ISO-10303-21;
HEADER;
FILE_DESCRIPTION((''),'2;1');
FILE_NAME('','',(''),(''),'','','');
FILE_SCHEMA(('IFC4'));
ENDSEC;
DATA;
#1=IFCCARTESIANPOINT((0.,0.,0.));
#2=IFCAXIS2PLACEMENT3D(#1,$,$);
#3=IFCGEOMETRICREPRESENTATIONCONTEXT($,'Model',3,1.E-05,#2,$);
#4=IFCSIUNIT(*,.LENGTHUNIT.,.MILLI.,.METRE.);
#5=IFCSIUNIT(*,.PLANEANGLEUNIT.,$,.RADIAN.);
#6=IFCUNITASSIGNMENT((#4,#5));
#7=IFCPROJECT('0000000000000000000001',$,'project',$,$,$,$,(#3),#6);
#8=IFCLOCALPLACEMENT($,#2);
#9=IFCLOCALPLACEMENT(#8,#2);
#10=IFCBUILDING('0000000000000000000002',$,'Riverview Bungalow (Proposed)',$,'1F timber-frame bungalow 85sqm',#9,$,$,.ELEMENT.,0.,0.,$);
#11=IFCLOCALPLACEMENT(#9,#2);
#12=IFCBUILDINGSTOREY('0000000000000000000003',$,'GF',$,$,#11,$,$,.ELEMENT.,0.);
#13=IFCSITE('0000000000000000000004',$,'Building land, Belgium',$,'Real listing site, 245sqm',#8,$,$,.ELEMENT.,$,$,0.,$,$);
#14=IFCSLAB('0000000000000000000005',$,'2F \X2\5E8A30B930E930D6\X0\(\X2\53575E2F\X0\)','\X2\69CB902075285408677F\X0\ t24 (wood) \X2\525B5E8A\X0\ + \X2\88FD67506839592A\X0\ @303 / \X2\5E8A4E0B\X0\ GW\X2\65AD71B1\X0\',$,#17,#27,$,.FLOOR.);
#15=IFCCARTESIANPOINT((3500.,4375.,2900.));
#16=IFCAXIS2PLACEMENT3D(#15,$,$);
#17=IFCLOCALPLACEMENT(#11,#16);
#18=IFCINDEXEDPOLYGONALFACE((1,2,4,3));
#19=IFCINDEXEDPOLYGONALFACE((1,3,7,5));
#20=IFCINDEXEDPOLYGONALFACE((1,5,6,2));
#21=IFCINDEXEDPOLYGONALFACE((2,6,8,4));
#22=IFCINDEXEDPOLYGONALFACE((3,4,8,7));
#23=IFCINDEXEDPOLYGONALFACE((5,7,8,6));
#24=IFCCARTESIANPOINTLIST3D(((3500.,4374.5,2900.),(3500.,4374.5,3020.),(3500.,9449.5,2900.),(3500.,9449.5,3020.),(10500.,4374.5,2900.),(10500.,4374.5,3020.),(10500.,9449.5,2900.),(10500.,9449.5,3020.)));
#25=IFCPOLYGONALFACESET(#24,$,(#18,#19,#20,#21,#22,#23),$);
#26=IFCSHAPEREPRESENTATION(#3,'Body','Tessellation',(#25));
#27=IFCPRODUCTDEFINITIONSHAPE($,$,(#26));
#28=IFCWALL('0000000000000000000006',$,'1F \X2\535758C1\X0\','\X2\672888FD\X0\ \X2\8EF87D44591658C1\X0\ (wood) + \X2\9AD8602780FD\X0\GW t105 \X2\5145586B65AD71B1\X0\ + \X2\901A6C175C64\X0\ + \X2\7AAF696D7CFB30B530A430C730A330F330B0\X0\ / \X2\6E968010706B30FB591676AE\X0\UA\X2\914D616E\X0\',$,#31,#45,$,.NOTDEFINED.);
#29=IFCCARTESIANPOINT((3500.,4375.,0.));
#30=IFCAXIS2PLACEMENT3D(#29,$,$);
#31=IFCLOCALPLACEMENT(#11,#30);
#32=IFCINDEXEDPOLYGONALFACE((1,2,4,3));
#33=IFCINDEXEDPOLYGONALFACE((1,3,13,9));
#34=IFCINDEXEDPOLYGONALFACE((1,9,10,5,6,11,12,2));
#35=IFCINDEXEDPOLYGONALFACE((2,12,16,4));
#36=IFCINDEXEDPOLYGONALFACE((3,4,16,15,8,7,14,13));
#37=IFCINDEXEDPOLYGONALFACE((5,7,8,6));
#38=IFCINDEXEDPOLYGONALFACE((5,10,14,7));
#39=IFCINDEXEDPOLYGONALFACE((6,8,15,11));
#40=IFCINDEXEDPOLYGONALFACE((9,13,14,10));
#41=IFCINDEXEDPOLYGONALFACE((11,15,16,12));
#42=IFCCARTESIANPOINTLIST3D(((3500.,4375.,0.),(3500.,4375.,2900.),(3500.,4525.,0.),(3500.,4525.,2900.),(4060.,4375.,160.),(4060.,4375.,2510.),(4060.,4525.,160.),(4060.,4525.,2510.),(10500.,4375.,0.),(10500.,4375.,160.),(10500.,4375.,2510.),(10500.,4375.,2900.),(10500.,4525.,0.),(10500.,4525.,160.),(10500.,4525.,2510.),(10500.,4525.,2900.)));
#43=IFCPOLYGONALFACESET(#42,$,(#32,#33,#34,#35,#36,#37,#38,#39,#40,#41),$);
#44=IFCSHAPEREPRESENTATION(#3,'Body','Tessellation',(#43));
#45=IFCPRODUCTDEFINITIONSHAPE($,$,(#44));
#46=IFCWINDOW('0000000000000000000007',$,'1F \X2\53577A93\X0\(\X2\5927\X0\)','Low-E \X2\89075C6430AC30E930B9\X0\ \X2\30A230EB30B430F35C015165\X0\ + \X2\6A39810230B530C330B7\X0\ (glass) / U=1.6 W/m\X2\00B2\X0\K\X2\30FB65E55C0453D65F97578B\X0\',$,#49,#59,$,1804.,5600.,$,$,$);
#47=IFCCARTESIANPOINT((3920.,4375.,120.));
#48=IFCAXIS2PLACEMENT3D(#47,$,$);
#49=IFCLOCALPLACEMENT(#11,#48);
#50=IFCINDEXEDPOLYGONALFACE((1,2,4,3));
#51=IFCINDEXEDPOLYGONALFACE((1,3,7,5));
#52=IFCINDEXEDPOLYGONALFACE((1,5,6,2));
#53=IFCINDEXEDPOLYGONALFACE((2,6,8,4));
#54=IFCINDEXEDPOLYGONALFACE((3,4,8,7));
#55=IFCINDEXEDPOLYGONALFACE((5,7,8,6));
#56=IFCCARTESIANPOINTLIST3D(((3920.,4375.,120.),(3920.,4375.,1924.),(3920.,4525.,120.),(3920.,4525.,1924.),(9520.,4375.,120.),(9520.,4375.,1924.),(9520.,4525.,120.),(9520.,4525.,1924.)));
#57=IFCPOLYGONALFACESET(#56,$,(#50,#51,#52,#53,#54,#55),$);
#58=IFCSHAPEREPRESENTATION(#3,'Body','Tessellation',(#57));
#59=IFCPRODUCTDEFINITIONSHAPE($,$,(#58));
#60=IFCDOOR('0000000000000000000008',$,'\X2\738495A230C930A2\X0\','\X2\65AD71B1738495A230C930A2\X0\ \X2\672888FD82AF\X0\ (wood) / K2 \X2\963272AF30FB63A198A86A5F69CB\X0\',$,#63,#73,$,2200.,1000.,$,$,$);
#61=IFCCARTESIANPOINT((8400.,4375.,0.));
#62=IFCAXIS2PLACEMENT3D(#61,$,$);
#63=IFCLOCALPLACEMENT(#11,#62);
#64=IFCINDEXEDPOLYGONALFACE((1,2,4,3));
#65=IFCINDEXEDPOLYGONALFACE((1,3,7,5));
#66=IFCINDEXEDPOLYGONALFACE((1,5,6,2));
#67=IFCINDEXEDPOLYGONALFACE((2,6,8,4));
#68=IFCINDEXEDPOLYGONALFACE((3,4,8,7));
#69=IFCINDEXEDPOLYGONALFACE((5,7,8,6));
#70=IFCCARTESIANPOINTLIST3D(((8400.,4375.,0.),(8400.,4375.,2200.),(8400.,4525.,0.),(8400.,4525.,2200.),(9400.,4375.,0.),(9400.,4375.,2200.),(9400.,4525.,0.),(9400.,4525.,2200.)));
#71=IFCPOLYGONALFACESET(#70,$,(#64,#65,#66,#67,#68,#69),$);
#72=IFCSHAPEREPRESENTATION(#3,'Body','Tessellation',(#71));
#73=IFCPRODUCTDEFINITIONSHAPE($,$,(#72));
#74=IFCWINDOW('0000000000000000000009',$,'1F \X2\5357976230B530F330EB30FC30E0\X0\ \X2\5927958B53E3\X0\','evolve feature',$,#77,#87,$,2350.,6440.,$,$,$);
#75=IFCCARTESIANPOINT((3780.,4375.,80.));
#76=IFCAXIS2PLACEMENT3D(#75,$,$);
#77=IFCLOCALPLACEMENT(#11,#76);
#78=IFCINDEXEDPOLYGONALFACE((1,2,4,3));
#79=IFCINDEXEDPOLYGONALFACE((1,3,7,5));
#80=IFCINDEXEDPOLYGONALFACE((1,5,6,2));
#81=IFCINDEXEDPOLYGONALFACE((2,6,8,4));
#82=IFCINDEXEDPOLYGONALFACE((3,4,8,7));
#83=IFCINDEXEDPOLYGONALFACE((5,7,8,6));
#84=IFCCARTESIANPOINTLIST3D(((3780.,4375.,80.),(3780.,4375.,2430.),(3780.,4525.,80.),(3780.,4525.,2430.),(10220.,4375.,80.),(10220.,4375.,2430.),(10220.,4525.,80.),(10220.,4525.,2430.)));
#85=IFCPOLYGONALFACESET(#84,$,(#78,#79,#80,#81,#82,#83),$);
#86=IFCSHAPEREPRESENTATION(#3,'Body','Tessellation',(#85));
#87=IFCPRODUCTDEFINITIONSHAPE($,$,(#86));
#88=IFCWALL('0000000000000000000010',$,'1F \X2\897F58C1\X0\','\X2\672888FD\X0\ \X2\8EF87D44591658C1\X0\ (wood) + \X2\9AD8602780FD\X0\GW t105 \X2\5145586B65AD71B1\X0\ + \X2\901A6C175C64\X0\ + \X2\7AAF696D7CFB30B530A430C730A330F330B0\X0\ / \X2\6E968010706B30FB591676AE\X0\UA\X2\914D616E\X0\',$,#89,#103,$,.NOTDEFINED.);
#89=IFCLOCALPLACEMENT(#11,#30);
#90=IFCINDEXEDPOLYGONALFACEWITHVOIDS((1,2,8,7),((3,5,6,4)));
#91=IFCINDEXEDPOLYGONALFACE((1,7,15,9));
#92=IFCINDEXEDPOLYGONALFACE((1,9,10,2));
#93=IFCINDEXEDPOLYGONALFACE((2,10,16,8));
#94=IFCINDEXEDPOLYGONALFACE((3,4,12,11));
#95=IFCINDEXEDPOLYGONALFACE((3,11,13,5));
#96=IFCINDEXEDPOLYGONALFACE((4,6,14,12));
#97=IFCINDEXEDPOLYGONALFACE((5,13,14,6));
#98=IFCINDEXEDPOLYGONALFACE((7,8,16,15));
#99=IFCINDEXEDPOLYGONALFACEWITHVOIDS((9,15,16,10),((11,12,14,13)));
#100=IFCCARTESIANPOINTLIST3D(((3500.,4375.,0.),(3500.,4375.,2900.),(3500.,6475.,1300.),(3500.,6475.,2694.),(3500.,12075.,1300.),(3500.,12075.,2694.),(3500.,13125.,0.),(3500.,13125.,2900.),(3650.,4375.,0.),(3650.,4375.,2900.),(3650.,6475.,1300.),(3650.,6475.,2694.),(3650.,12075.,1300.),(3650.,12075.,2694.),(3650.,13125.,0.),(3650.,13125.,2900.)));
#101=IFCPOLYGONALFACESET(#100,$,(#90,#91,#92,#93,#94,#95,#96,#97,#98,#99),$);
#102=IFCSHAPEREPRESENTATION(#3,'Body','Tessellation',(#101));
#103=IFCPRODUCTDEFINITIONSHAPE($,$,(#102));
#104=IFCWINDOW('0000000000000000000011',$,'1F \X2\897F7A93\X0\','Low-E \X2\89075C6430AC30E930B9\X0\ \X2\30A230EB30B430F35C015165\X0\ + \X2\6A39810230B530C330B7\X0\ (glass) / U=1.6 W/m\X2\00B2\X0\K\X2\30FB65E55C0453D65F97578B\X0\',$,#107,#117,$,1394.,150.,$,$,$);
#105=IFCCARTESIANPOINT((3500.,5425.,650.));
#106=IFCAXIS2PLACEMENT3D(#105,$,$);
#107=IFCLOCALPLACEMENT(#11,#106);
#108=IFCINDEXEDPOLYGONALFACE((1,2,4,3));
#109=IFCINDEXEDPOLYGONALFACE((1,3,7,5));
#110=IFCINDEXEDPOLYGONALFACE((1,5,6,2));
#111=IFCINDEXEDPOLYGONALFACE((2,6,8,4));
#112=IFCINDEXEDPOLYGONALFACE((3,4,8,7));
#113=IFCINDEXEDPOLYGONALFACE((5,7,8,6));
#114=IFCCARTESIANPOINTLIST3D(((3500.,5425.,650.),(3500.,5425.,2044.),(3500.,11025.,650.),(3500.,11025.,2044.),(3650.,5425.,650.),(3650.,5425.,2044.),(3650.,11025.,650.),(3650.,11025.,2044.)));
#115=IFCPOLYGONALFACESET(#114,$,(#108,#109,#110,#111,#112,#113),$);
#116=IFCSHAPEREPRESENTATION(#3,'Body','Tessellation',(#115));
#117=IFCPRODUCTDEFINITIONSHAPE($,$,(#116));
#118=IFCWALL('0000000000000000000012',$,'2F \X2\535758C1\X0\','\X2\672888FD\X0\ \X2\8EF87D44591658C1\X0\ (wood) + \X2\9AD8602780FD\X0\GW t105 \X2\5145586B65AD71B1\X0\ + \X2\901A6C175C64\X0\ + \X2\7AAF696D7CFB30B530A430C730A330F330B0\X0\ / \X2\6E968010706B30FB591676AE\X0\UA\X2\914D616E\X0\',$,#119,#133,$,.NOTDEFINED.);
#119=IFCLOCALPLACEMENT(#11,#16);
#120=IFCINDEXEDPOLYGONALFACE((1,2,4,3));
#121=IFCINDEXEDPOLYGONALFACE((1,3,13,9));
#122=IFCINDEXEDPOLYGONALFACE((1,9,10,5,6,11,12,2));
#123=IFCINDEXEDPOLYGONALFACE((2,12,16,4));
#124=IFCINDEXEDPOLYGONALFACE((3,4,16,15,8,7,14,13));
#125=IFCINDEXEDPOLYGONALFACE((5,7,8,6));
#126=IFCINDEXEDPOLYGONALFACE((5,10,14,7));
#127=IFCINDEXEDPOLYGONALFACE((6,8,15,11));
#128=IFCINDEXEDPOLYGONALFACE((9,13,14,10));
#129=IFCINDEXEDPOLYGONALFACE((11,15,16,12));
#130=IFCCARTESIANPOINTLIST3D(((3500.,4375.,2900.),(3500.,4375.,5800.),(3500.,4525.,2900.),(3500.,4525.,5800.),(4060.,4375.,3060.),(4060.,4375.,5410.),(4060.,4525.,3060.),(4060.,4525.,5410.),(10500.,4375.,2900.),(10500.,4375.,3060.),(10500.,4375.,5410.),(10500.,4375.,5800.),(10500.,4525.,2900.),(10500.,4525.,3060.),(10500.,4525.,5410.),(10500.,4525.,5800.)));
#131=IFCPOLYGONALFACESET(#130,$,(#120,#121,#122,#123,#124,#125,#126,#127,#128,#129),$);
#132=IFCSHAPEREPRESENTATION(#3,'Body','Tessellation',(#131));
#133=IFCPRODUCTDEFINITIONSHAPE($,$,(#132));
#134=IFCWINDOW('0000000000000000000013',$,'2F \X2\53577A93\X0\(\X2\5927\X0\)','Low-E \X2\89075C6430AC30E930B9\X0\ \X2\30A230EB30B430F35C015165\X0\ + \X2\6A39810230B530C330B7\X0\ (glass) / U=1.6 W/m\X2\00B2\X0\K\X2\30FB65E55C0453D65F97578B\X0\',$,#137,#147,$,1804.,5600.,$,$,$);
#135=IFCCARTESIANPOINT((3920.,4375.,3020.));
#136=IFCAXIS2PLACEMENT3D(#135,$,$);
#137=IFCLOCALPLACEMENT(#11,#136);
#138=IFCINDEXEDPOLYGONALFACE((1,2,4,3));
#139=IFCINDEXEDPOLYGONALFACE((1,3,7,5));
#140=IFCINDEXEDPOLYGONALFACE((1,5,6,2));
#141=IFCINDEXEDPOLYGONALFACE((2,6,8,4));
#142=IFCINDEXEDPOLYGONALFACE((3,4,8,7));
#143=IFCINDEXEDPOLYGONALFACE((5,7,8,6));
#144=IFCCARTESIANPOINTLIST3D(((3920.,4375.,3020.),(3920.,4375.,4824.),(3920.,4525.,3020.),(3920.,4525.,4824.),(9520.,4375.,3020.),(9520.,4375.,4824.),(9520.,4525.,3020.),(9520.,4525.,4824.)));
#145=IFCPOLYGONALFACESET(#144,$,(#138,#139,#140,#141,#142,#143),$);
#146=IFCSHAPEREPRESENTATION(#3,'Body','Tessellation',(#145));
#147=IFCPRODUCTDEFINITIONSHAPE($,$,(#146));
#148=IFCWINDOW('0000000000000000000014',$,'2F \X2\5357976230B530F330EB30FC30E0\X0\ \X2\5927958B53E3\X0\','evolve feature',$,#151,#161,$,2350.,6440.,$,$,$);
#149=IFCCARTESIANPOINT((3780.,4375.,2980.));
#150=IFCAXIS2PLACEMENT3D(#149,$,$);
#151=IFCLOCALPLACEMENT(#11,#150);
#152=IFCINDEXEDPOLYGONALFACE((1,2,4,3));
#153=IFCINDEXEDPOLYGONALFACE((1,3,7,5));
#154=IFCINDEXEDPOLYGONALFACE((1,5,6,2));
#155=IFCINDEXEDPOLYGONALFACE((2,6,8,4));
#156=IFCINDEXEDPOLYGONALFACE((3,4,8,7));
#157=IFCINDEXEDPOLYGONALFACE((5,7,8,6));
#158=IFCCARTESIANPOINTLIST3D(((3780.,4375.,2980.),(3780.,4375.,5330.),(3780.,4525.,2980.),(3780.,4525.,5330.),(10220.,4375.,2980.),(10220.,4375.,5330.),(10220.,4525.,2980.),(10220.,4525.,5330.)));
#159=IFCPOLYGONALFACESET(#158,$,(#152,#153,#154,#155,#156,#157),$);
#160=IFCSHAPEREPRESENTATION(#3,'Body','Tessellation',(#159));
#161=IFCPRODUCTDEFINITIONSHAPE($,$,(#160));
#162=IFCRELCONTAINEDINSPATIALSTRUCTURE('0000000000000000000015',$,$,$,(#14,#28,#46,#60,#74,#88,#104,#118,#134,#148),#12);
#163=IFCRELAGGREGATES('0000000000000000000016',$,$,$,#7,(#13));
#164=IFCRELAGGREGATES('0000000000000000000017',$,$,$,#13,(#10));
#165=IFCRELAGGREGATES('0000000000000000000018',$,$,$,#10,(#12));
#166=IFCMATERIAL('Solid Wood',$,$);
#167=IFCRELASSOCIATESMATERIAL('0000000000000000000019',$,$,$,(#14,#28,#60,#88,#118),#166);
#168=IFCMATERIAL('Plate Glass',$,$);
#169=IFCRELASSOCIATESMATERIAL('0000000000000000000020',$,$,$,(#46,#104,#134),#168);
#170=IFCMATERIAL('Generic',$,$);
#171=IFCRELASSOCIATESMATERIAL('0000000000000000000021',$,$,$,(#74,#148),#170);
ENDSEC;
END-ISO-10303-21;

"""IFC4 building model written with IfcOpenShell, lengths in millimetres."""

from ifc_helpers import new_model, si_unit, frame, frame_2d, origin, place, context, project, spatial, rectangle, extrude, material, element, fill, save


model = new_model("IFC4")

# Units and contexts
model_context = context("Model", 3, precision=1e-05, world=origin())
ifc_project = project(units=[si_unit("LENGTHUNIT", "METRE", prefix="MILLI"), si_unit("PLANEANGLEUNIT", "RADIAN")], contexts=[model_context])

# Site, building, storey
site_placement = place(None, origin())
site = spatial("IfcSite", under=ifc_project, at=site_placement, Name="Building land, Belgium", ObjectType="Real listing site, 245sqm", CompositionType="ELEMENT", RefElevation=0.0)
building_placement = place(site_placement, origin())
building = spatial("IfcBuilding", under=site, at=building_placement, Name="Riverview Bungalow (Proposed)", ObjectType="1F timber-frame bungalow 85sqm", CompositionType="ELEMENT", ElevationOfRefHeight=0.0, ElevationOfTerrain=0.0)
storey_placement = place(building_placement, origin())
storey = spatial("IfcBuildingStorey", under=building, at=storey_placement, Name="GF", CompositionType="ELEMENT", Elevation=0.0)

# Slab
ifc_material_1 = material(Name="Solid Wood")
slab_1_placement = place(storey_placement, frame((3500.0, 4375.0, 2900.0)))
element("IfcSlab", 1, at=slab_1_placement, inside=storey, material=ifc_material_1, Name="2F 床スラブ(南帯)", Description="構造用合板 t24 (wood) 剛床 + 製材根太 @303 / 床下 GW断熱", PredefinedType="FLOOR", context=model_context, shape_type="SweptSolid", body=[
    extrude(rectangle(XDim=7000.0, YDim=5075.0, at=frame_2d((3500.0, 2537.0))), frame((3500.0, 4375.0, 2900.0)), (0.0, 0.0, 1.0), 120.0),
])
ifc_material_2 = material(Name="Generic")

# Wall, openings, windows, door
wall_1_placement = place(storey_placement, frame((3500.0, 4375.0, 0.0)))
wall_1 = element("IfcWall", 2, at=wall_1_placement, inside=storey, material=ifc_material_1, Name="1F 南壁", Description="木製 軸組外壁 (wood) + 高性能GW t105 充填断熱 + 通気層 + 窯業系サイディング / 準耐火・外皮UA配慮", PredefinedType="NOTDEFINED", context=model_context, shape_type="SweptSolid", body=[
    extrude(rectangle(XDim=7000.0, YDim=150.0, at=frame_2d((3500.0, 75.0))), frame((3500.0, 4375.0, 0.0)), (0.0, 0.0, 1.0), 2900.0),
])
opening_1_placement = place(storey_placement, frame((3920.0, 4375.0, 120.0)))
opening_1 = element("IfcOpeningElement", 3, at=opening_1_placement, cuts=wall_1, PredefinedType="NOTDEFINED", context=model_context, shape_type="SweptSolid", body=[
    extrude(rectangle(XDim=5600.0, YDim=150.0, at=frame_2d((2800.0, 75.0))), frame((3920.0, 4375.0, 120.0)), (0.0, 0.0, 1.0), 1804.0),
])
opening_2_placement = place(storey_placement, frame((8400.0, 4375.0, 0.0)))
opening_2 = element("IfcOpeningElement", 4, at=opening_2_placement, cuts=wall_1, PredefinedType="NOTDEFINED", context=model_context, shape_type="SweptSolid", body=[
    extrude(rectangle(XDim=1000.0, YDim=150.0, at=frame_2d((500.0, 75.0))), frame((8400.0, 4375.0, 0.0)), (0.0, 0.0, 1.0), 2200.0),
])
opening_3_placement = place(storey_placement, frame((3780.0, 4375.0, 80.0)))
opening_3 = element("IfcOpeningElement", 5, at=opening_3_placement, cuts=wall_1, PredefinedType="NOTDEFINED", context=model_context, shape_type="SweptSolid", body=[
    extrude(rectangle(XDim=6440.0, YDim=150.0, at=frame_2d((3220.0, 75.0))), frame((3780.0, 4375.0, 80.0)), (0.0, 0.0, 1.0), 2350.0),
])
ifc_material_3 = material(Name="Plate Glass")
window_1_placement = place(storey_placement, frame((3920.0, 4375.0, 120.0)))
window_1 = element("IfcWindow", 6, at=window_1_placement, inside=storey, material=ifc_material_3, Name="1F 南窓(大)", Description="Low-E 複層ガラス アルゴン封入 + 樹脂サッシ (glass) / U=1.6 W/m²K・日射取得型", OverallHeight=1804.0, OverallWidth=5600.0, context=model_context, shape_type="SweptSolid", body=[
    extrude(rectangle(XDim=5600.0, YDim=150.0, at=frame_2d((2800.0, 75.0))), frame((3920.0, 4375.0, 120.0)), (0.0, 0.0, 1.0), 1804.0),
])
fill(opening_1, window_1)
door_placement = place(storey_placement, frame((8400.0, 4375.0, 0.0)))
door = element("IfcDoor", 7, at=door_placement, inside=storey, material=ifc_material_1, Name="玄関ドア", Description="断熱玄関ドア 木製芯 (wood) / K2 防犯・採風機構", OverallHeight=2200.0, OverallWidth=1000.0, context=model_context, shape_type="SweptSolid", body=[
    extrude(rectangle(XDim=1000.0, YDim=150.0, at=frame_2d((500.0, 75.0))), frame((8400.0, 4375.0, 0.0)), (0.0, 0.0, 1.0), 2200.0),
])
fill(opening_2, door)
window_2_placement = place(storey_placement, frame((3780.0, 4375.0, 80.0)))
window_2 = element("IfcWindow", 8, at=window_2_placement, inside=storey, material=ifc_material_2, Name="1F 南面サンルーム 大開口", Description="evolve feature", OverallHeight=2350.0, OverallWidth=6440.0, context=model_context, shape_type="SweptSolid", body=[
    extrude(rectangle(XDim=6440.0, YDim=150.0, at=frame_2d((3220.0, 75.0))), frame((3780.0, 4375.0, 80.0)), (0.0, 0.0, 1.0), 2350.0),
])
fill(opening_3, window_2)

# Wall, opening, window
wall_2_placement = place(storey_placement, frame((3500.0, 4375.0, 0.0)))
wall_2 = element("IfcWall", 9, at=wall_2_placement, inside=storey, material=ifc_material_1, Name="1F 西壁", Description="木製 軸組外壁 (wood) + 高性能GW t105 充填断熱 + 通気層 + 窯業系サイディング / 準耐火・外皮UA配慮", PredefinedType="NOTDEFINED", context=model_context, shape_type="SweptSolid", body=[
    extrude(rectangle(XDim=150.0, YDim=8750.0, at=frame_2d((75.0, 4375.0))), frame((3500.0, 4375.0, 0.0)), (0.0, 0.0, 1.0), 2900.0),
])
opening_4_placement = place(storey_placement, frame((3500.0, 5425.0, 650.0)))
opening_4 = element("IfcOpeningElement", 10, at=opening_4_placement, cuts=wall_2, PredefinedType="NOTDEFINED", context=model_context, shape_type="SweptSolid", body=[
    extrude(rectangle(XDim=150.0, YDim=5600.0, at=frame_2d((75.0, 2800.0))), frame((3500.0, 5425.0, 650.0)), (0.0, 0.0, 1.0), 1394.0),
])
window_3_placement = place(storey_placement, frame((3500.0, 5425.0, 650.0)))
window_3 = element("IfcWindow", 11, at=window_3_placement, inside=storey, material=ifc_material_3, Name="1F 西窓", Description="Low-E 複層ガラス アルゴン封入 + 樹脂サッシ (glass) / U=1.6 W/m²K・日射取得型", OverallHeight=1394.0, OverallWidth=150.0, context=model_context, shape_type="SweptSolid", body=[
    extrude(rectangle(XDim=150.0, YDim=5600.0, at=frame_2d((75.0, 2800.0))), frame((3500.0, 5425.0, 650.0)), (0.0, 0.0, 1.0), 1394.0),
])
fill(opening_4, window_3)

# Wall, openings, windows
wall_3_placement = place(storey_placement, frame((3500.0, 4375.0, 2900.0)))
wall_3 = element("IfcWall", 12, at=wall_3_placement, inside=storey, material=ifc_material_1, Name="2F 南壁", Description="木製 軸組外壁 (wood) + 高性能GW t105 充填断熱 + 通気層 + 窯業系サイディング / 準耐火・外皮UA配慮", PredefinedType="NOTDEFINED", context=model_context, shape_type="SweptSolid", body=[
    extrude(rectangle(XDim=7000.0, YDim=150.0, at=frame_2d((3500.0, 75.0))), frame((3500.0, 4375.0, 2900.0)), (0.0, 0.0, 1.0), 2900.0),
])
opening_5_placement = place(storey_placement, frame((3920.0, 4375.0, 3020.0)))
opening_5 = element("IfcOpeningElement", 13, at=opening_5_placement, cuts=wall_3, PredefinedType="NOTDEFINED", context=model_context, shape_type="SweptSolid", body=[
    extrude(rectangle(XDim=5600.0, YDim=150.0, at=frame_2d((2800.0, 75.0))), frame((3920.0, 4375.0, 3020.0)), (0.0, 0.0, 1.0), 1804.0),
])
opening_6_placement = place(storey_placement, frame((3780.0, 4375.0, 2980.0)))
opening_6 = element("IfcOpeningElement", 14, at=opening_6_placement, cuts=wall_3, PredefinedType="NOTDEFINED", context=model_context, shape_type="SweptSolid", body=[
    extrude(rectangle(XDim=6440.0, YDim=150.0, at=frame_2d((3220.0, 75.0))), frame((3780.0, 4375.0, 2980.0)), (0.0, 0.0, 1.0), 2350.0),
])
window_4_placement = place(storey_placement, frame((3920.0, 4375.0, 3020.0)))
window_4 = element("IfcWindow", 15, at=window_4_placement, inside=storey, material=ifc_material_3, Name="2F 南窓(大)", Description="Low-E 複層ガラス アルゴン封入 + 樹脂サッシ (glass) / U=1.6 W/m²K・日射取得型", OverallHeight=1804.0, OverallWidth=5600.0, context=model_context, shape_type="SweptSolid", body=[
    extrude(rectangle(XDim=5600.0, YDim=150.0, at=frame_2d((2800.0, 75.0))), frame((3920.0, 4375.0, 3020.0)), (0.0, 0.0, 1.0), 1804.0),
])
fill(opening_5, window_4)
window_5_placement = place(storey_placement, frame((3780.0, 4375.0, 2980.0)))
window_5 = element("IfcWindow", 16, at=window_5_placement, inside=storey, material=ifc_material_2, Name="2F 南面サンルーム 大開口", Description="evolve feature", OverallHeight=2350.0, OverallWidth=6440.0, context=model_context, shape_type="SweptSolid", body=[
    extrude(rectangle(XDim=6440.0, YDim=150.0, at=frame_2d((3220.0, 75.0))), frame((3780.0, 4375.0, 2980.0)), (0.0, 0.0, 1.0), 2350.0),
])
fill(opening_6, window_5)

save(model, "model.ifc")
